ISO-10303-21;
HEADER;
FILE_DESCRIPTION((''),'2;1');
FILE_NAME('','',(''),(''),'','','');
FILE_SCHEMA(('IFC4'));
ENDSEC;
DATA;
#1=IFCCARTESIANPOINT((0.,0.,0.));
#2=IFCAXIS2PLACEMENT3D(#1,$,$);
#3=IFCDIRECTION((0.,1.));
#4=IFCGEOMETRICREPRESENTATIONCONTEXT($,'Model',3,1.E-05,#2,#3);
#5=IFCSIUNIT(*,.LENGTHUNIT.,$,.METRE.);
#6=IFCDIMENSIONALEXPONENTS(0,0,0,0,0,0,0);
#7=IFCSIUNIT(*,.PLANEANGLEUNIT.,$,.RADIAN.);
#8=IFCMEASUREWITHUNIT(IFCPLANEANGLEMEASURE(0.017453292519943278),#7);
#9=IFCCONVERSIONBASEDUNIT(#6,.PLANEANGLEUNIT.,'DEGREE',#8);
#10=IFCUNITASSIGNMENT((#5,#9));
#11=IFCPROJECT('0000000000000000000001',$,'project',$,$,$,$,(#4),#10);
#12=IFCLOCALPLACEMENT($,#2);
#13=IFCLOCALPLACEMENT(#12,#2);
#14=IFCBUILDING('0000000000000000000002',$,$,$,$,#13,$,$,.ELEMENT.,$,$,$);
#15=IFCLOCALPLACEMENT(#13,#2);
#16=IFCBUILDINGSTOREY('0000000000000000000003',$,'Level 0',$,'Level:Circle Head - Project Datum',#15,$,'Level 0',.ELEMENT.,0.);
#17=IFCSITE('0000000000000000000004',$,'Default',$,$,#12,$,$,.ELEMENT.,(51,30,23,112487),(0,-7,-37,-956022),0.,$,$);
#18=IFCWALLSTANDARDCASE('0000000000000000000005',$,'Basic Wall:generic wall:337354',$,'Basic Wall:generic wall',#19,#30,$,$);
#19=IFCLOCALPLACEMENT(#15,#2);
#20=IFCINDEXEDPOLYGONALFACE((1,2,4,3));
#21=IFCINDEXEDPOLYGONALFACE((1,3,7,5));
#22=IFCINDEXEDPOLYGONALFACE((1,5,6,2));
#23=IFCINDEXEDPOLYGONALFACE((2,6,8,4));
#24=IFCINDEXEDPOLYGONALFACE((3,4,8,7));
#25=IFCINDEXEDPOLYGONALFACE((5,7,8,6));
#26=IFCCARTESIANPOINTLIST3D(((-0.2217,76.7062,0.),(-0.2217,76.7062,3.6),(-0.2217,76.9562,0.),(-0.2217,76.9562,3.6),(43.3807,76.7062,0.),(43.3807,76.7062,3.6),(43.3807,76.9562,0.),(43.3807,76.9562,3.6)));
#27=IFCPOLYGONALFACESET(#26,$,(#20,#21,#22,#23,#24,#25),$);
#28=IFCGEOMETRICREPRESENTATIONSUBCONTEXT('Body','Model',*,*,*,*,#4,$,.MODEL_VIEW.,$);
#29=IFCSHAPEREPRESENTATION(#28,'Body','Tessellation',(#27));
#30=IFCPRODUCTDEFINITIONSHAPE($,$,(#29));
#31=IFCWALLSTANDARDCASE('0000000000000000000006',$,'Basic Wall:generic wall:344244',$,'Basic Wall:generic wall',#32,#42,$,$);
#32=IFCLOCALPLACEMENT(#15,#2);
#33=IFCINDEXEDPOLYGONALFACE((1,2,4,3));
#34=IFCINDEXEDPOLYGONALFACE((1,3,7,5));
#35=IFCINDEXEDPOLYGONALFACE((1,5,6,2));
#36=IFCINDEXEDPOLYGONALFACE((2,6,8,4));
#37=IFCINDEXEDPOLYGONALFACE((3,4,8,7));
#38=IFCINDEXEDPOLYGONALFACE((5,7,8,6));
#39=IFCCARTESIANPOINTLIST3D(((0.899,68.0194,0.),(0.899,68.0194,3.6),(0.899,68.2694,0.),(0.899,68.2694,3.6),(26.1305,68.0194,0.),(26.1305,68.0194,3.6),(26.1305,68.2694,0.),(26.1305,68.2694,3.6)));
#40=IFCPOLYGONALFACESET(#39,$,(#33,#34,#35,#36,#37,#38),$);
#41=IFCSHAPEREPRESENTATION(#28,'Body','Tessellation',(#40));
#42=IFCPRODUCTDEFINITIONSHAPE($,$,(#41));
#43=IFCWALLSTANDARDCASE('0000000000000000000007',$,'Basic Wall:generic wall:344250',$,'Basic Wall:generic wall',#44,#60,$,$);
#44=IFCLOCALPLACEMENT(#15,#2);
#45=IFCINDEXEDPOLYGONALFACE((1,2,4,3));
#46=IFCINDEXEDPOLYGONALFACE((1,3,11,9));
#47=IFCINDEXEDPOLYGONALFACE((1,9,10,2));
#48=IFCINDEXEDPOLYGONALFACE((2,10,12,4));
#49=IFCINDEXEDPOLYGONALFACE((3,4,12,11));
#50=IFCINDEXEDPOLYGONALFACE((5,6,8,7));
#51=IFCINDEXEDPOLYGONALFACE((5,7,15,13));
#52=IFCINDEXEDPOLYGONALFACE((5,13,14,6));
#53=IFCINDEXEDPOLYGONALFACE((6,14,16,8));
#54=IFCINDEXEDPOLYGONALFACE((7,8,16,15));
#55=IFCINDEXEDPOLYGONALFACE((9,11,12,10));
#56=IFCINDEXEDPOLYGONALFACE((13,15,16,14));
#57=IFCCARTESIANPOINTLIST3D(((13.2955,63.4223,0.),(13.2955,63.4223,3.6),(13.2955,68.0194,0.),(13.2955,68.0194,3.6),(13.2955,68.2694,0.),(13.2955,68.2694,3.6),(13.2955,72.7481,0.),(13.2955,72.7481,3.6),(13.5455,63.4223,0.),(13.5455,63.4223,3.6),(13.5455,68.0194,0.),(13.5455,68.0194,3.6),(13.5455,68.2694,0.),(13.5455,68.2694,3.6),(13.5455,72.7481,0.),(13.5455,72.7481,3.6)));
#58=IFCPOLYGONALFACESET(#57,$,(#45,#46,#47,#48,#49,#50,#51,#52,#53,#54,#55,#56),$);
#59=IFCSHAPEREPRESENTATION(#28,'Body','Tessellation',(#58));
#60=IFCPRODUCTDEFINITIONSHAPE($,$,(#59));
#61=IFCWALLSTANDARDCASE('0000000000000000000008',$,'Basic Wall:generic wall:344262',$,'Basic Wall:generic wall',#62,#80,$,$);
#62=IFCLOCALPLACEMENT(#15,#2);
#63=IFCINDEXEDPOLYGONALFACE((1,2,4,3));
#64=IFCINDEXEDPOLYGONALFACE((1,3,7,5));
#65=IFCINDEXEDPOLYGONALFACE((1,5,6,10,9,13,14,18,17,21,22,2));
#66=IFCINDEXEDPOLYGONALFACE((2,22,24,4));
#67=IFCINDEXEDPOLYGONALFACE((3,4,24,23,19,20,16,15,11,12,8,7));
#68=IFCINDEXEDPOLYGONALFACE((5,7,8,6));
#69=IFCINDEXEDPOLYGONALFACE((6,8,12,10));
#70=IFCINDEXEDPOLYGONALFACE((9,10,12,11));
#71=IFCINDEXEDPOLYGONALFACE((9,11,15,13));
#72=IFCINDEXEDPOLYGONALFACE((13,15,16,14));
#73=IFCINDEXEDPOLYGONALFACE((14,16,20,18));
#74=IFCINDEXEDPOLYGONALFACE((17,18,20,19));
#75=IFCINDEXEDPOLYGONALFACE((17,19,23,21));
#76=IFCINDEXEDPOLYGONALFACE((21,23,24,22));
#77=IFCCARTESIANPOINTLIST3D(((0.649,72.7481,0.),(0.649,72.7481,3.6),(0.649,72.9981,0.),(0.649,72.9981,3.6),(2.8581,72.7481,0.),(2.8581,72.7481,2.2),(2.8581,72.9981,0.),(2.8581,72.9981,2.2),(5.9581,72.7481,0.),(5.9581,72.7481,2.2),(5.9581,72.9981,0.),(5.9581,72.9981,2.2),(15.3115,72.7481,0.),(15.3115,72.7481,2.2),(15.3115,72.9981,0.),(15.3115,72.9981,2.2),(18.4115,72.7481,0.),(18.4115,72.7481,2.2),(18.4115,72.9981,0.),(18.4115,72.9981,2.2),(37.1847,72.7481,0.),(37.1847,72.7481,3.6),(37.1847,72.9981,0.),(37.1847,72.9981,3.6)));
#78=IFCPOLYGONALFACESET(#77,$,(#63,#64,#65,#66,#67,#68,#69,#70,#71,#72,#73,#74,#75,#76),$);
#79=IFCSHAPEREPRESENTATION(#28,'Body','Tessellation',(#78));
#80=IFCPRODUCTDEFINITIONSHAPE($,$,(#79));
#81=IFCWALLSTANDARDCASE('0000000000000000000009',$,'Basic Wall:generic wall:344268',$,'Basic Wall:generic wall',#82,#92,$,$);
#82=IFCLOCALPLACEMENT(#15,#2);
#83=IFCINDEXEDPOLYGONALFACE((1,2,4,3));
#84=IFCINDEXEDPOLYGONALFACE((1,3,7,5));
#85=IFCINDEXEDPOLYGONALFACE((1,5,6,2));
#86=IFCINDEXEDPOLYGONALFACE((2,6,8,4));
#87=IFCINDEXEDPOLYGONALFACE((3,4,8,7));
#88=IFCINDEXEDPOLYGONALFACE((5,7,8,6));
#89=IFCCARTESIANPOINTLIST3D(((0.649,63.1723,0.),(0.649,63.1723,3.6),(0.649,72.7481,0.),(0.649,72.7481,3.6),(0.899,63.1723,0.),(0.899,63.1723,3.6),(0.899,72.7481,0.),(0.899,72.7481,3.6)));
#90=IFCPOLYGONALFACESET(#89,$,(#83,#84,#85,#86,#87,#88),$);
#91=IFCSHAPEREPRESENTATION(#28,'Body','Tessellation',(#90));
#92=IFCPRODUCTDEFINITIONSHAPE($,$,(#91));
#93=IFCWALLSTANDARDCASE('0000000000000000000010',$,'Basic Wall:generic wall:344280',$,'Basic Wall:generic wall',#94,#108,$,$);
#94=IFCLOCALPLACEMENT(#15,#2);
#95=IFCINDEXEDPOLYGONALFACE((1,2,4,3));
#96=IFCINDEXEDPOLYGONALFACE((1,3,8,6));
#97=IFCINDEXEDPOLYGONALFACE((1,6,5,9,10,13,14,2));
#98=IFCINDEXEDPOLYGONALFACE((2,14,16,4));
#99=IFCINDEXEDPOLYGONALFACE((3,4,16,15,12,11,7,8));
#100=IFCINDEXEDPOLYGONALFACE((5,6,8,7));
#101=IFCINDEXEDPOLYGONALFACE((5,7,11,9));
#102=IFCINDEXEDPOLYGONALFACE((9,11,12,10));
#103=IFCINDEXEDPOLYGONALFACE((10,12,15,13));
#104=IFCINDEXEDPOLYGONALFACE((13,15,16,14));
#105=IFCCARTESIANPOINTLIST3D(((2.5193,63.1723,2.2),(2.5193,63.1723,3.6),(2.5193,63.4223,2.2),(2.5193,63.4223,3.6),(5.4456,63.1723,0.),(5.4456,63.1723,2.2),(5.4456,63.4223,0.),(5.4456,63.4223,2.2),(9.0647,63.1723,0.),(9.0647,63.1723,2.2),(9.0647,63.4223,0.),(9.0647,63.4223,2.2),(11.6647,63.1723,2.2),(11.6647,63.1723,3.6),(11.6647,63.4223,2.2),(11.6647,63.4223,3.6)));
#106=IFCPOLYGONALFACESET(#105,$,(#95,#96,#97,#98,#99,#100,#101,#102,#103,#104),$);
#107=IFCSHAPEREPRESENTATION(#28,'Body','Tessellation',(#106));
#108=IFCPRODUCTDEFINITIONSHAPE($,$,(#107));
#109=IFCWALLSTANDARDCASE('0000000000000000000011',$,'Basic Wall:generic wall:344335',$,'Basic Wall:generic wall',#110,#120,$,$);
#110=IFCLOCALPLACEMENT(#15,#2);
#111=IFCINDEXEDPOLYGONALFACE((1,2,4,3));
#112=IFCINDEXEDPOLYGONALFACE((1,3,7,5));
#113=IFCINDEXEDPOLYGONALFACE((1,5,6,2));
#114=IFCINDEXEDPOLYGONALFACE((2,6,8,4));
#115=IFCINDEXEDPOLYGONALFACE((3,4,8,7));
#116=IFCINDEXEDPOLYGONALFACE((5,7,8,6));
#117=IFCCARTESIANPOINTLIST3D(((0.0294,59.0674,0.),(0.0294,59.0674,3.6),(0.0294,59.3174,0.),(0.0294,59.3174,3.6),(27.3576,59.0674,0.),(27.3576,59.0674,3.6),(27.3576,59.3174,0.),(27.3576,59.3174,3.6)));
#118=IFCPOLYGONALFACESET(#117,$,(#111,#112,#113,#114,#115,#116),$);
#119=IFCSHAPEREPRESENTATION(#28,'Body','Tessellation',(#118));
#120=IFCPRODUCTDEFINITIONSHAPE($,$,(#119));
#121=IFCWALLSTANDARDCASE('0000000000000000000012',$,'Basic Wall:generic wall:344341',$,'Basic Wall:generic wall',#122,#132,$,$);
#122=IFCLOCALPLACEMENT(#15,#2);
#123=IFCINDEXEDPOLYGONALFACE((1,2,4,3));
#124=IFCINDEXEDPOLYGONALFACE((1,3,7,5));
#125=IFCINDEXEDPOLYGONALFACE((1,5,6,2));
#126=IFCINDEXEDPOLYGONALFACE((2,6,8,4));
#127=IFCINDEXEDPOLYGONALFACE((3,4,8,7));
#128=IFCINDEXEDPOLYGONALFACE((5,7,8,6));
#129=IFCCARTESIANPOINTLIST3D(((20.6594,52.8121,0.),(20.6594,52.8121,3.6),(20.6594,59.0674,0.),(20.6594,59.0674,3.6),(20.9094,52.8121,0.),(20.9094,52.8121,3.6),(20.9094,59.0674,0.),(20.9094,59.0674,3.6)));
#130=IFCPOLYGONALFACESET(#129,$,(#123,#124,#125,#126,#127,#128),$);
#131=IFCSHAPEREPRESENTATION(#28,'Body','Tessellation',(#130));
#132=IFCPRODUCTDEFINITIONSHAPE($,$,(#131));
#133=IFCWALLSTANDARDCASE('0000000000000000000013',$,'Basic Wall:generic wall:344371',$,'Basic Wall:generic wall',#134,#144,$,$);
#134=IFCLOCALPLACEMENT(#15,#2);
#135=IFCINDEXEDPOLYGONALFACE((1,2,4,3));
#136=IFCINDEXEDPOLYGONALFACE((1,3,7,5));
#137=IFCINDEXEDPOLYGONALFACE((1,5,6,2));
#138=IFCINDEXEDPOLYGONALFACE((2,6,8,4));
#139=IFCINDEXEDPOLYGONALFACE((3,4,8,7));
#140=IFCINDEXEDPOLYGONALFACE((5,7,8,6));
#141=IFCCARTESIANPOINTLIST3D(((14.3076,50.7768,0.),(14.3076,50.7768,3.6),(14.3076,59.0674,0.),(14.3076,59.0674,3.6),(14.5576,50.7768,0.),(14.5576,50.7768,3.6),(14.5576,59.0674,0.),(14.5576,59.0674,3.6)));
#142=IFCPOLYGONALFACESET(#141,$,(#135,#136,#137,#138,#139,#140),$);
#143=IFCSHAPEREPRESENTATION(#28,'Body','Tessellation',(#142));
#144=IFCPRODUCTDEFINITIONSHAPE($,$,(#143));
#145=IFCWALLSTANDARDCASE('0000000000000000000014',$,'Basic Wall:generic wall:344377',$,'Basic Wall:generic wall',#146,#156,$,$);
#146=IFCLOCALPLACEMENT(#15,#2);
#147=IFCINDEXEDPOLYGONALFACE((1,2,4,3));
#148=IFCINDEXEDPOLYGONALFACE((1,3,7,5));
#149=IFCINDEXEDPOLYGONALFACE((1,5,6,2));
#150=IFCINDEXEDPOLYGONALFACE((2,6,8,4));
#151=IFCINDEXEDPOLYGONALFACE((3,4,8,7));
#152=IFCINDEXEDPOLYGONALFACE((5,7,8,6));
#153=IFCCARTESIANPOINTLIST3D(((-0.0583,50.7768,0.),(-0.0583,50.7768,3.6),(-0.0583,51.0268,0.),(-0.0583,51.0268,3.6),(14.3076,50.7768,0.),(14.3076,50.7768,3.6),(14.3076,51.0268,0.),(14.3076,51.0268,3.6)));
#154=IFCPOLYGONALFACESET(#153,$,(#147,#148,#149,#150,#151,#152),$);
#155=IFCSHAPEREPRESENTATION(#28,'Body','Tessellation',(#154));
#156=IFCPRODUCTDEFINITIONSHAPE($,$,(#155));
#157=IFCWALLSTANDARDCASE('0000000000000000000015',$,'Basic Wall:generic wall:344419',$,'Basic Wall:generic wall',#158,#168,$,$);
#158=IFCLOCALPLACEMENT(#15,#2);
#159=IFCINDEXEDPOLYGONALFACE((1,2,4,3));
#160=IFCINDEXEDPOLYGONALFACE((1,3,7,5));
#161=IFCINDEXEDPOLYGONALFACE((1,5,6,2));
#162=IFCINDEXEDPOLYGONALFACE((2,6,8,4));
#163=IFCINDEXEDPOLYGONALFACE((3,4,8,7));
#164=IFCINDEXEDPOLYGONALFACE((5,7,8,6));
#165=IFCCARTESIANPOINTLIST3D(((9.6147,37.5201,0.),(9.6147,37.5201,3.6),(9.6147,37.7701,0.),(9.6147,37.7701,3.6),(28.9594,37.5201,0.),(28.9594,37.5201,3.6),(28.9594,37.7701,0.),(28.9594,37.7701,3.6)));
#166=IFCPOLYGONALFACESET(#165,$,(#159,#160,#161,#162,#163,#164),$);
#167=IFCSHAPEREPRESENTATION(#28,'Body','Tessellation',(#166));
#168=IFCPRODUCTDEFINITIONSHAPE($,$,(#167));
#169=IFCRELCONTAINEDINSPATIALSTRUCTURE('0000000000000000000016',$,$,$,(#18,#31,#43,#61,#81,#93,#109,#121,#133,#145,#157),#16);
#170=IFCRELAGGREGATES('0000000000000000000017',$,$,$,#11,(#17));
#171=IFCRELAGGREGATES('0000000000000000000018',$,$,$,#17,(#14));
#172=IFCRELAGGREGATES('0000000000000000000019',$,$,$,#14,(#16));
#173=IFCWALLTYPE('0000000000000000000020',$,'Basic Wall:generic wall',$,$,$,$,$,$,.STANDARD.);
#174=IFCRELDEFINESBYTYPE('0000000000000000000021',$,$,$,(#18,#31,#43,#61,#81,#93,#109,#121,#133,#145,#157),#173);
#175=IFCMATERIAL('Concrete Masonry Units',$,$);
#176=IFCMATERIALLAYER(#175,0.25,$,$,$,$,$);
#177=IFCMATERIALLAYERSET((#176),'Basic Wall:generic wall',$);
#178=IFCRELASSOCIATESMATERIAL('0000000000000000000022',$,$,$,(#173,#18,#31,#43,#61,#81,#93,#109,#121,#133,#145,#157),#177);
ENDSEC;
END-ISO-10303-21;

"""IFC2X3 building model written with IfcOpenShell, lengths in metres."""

from ifc_helpers import new_model, entity, si_unit, converted_unit, direction, frame, frame_2d, origin, place, context, subcontext, project, spatial, rectangle, extrude, material, layer, layer_set, layer_usage, type_object, element, save


model = new_model("IFC2X3")

# Units and contexts
model_context = context("Model", 3, precision=1e-05, world=origin(), true_north=direction((0.0, 1.0)))
body_context = subcontext(model_context, "Body", "Model", "MODEL_VIEW")
ifc_project = project(units=[si_unit("LENGTHUNIT", "METRE"), converted_unit("PLANEANGLEUNIT", "DEGREE", entity("IfcPlaneAngleMeasure", 0.017453292519943278), si_unit("PLANEANGLEUNIT", "RADIAN"), dimensions=[0, 0, 0, 0, 0, 0, 0])], contexts=[model_context])

# Site, building, storey
site_placement = place(None, origin())
site = spatial("IfcSite", under=ifc_project, at=site_placement, Name="Default", CompositionType="ELEMENT", RefLatitude=(51, 30, 23, 112487), RefLongitude=(0, -7, -37, -956022), RefElevation=0.0)
building_placement = place(site_placement, origin())
building = spatial("IfcBuilding", under=site, at=building_placement, CompositionType="ELEMENT")
storey_placement = place(building_placement, origin())
storey = spatial("IfcBuildingStorey", under=building, at=storey_placement, Name="Level 0", ObjectType="Level:Circle Head - Project Datum", LongName="Level 0", CompositionType="ELEMENT", Elevation=0.0)

# Walls
ifc_material_1 = material(Name="Concrete Masonry Units")
ifc_layer_1 = layer(ifc_material_1, 0.25)
ifc_layer_set_1 = layer_set([ifc_layer_1], Name="Basic Wall:generic wall")
ifc_layer_usage_1 = layer_usage(ifc_layer_set_1, "AXIS2", "POSITIVE", -0.125)
wall_type_1 = type_object("IfcWallType", Name="Basic Wall:generic wall", PredefinedType="STANDARD", material=ifc_layer_set_1)
wall_1_placement = place(storey_placement, frame((-0.2217, 76.8312, 0.0)))
element("IfcWallStandardCase", 1, at=wall_1_placement, inside=storey, type_object=wall_type_1, material=ifc_layer_usage_1, Name="Basic Wall:generic wall:337354", ObjectType="Basic Wall:generic wall", context=body_context, shape_type="SweptSolid", body=[
    extrude(rectangle(XDim=43.6023, YDim=0.25, at=frame_2d((21.8012, 0.0), x_axis=(-1.0, 0.0))), origin(), (0.0, 0.0, 1.0), 3.6),
])
ifc_layer_usage_2 = layer_usage(ifc_layer_set_1, "AXIS2", "NEGATIVE", 0.125)
wall_2_placement = place(storey_placement, frame((0.899, 68.1444, 0.0)))
element("IfcWallStandardCase", 2, at=wall_2_placement, inside=storey, type_object=wall_type_1, material=ifc_layer_usage_2, Name="Basic Wall:generic wall:344244", ObjectType="Basic Wall:generic wall", context=body_context, shape_type="SweptSolid", body=[
    extrude(rectangle(XDim=25.2315, YDim=0.25, at=frame_2d((12.6158, 0.0), x_axis=(-1.0, 0.0))), origin(), (0.0, 0.0, 1.0), 3.6),
])

# Wall, opening
ifc_layer_usage_3 = layer_usage(ifc_layer_set_1, "AXIS2", "NEGATIVE", 0.125)
wall_3_placement = place(storey_placement, frame((13.4205, 72.7481, 0.0), z_axis=(0.0, 0.0, 1.0), x_axis=(0.0, -1.0, 0.0)))
wall_3 = element("IfcWallStandardCase", 3, at=wall_3_placement, inside=storey, type_object=wall_type_1, material=ifc_layer_usage_3, Name="Basic Wall:generic wall:344250", ObjectType="Basic Wall:generic wall", context=body_context, shape_type="SweptSolid", body=[
    extrude(rectangle(XDim=9.3259, YDim=0.25, at=frame_2d((4.6629, 0.0), x_axis=(-1.0, 0.0))), origin(), (0.0, 0.0, 1.0), 3.6),
])
opening_1_placement = place(storey_placement, frame((13.4205, 72.7481, 0.0), z_axis=(0.0, 0.0, 1.0), x_axis=(0.0, -1.0, 0.0)))
element("IfcOpeningElement", 4, at=opening_1_placement, cuts=wall_3, ObjectType="Opening", context=body_context, shape_type="SweptSolid", body=[
    extrude(rectangle(XDim=3.6, YDim=0.25, at=frame_2d((0.0, 0.0), x_axis=(1.0, 0.0))), frame((4.7287, 0.0, 1.8), z_axis=(-1.0, 0.0, 0.0), x_axis=(0.0, 0.0, 1.0)), (0.0, 0.0, 1.0), 0.25),
])

# Wall, openings
ifc_layer_usage_4 = layer_usage(ifc_layer_set_1, "AXIS2", "NEGATIVE", 0.125)
wall_4_placement = place(storey_placement, frame((0.649, 72.8731, 0.0)))
wall_4 = element("IfcWallStandardCase", 5, at=wall_4_placement, inside=storey, type_object=wall_type_1, material=ifc_layer_usage_4, Name="Basic Wall:generic wall:344262", ObjectType="Basic Wall:generic wall", context=body_context, shape_type="SweptSolid", body=[
    extrude(rectangle(XDim=36.5356, YDim=0.25, at=frame_2d((18.2678, 0.0), x_axis=(1.0, 0.0))), origin(), (0.0, 0.0, 1.0), 3.6),
])
opening_2_placement = place(wall_4_placement, frame((5.3091, 0.125, 0.0)))
element("IfcOpeningElement", 6, at=opening_2_placement, cuts=wall_4, ObjectType="Opening", context=body_context, shape_type="SweptSolid", body=[
    extrude(rectangle(XDim=2.2, YDim=3.1, at=frame_2d((1.1, 1.55), x_axis=(1.0, 0.0))), frame((0.0, 0.0, 0.0), z_axis=(0.0, -1.0, 0.0), x_axis=(0.0, 0.0, 1.0)), (0.0, 0.0, 1.0), 0.25),
])
opening_3_placement = place(wall_4_placement, frame((17.7625, 0.125, 0.0)))
element("IfcOpeningElement", 7, at=opening_3_placement, cuts=wall_4, ObjectType="Opening", context=body_context, shape_type="SweptSolid", body=[
    extrude(rectangle(XDim=2.2, YDim=3.1, at=frame_2d((1.1, 1.55), x_axis=(1.0, 0.0))), frame((0.0, 0.0, 0.0), z_axis=(0.0, -1.0, 0.0), x_axis=(0.0, 0.0, 1.0)), (0.0, 0.0, 1.0), 0.25),
])

# Wall
ifc_layer_usage_5 = layer_usage(ifc_layer_set_1, "AXIS2", "NEGATIVE", 0.125)
wall_5_placement = place(storey_placement, frame((0.774, 63.1723, 0.0), z_axis=(0.0, 0.0, 1.0), x_axis=(0.0, 1.0, 0.0)))
element("IfcWallStandardCase", 8, at=wall_5_placement, inside=storey, type_object=wall_type_1, material=ifc_layer_usage_5, Name="Basic Wall:generic wall:344268", ObjectType="Basic Wall:generic wall", context=body_context, shape_type="SweptSolid", body=[
    extrude(rectangle(XDim=9.5759, YDim=0.25, at=frame_2d((4.7879, 0.0), x_axis=(-1.0, 0.0))), origin(), (0.0, 0.0, 1.0), 3.6),
])

# Wall, openings
ifc_layer_usage_6 = layer_usage(ifc_layer_set_1, "AXIS2", "NEGATIVE", 0.125)
wall_6_placement = place(storey_placement, frame((11.6647, 63.2973, 0.0), z_axis=(0.0, 0.0, 1.0), x_axis=(-1.0, 0.0, 0.0)))
wall_6 = element("IfcWallStandardCase", 9, at=wall_6_placement, inside=storey, type_object=wall_type_1, material=ifc_layer_usage_6, Name="Basic Wall:generic wall:344280", ObjectType="Basic Wall:generic wall", context=body_context, shape_type="SweptSolid", body=[
    extrude(rectangle(XDim=9.1454, YDim=0.25, at=frame_2d((4.5727, 0.0), x_axis=(-1.0, 0.0))), origin(), (0.0, 0.0, 1.0), 3.6),
])
opening_4_placement = place(wall_6_placement, frame((9.319, 0.125, 0.0)))
element("IfcOpeningElement", 10, at=opening_4_placement, cuts=wall_6, ObjectType="Opening", context=body_context, shape_type="SweptSolid", body=[
    extrude(rectangle(XDim=2.2, YDim=3.1, at=frame_2d((1.1, 1.55), x_axis=(1.0, 0.0))), frame((0.0, 0.0, 0.0), z_axis=(0.0, -1.0, 0.0), x_axis=(0.0, 0.0, 1.0)), (0.0, 0.0, 1.0), 0.25),
])
opening_5_placement = place(wall_6_placement, frame((2.6, 0.125, 0.0)))
element("IfcOpeningElement", 11, at=opening_5_placement, cuts=wall_6, ObjectType="Opening", context=body_context, shape_type="SweptSolid", body=[
    extrude(rectangle(XDim=2.2, YDim=3.1, at=frame_2d((1.1, 1.55), x_axis=(1.0, 0.0))), frame((0.0, 0.0, 0.0), z_axis=(0.0, -1.0, 0.0), x_axis=(0.0, 0.0, 1.0)), (0.0, 0.0, 1.0), 0.25),
])

# Walls
ifc_layer_usage_7 = layer_usage(ifc_layer_set_1, "AXIS2", "NEGATIVE", 0.125)
wall_7_placement = place(storey_placement, frame((0.0294, 59.1924, 0.0)))
element("IfcWallStandardCase", 12, at=wall_7_placement, inside=storey, type_object=wall_type_1, material=ifc_layer_usage_7, Name="Basic Wall:generic wall:344335", ObjectType="Basic Wall:generic wall", context=body_context, shape_type="SweptSolid", body=[
    extrude(rectangle(XDim=27.3282, YDim=0.25, at=frame_2d((13.6641, 0.0), x_axis=(-1.0, 0.0))), origin(), (0.0, 0.0, 1.0), 3.6),
])
ifc_layer_usage_8 = layer_usage(ifc_layer_set_1, "AXIS2", "NEGATIVE", 0.125)
wall_8_placement = place(storey_placement, frame((20.7844, 59.0674, 0.0), z_axis=(0.0, 0.0, 1.0), x_axis=(0.0, -1.0, 0.0)))
element("IfcWallStandardCase", 13, at=wall_8_placement, inside=storey, type_object=wall_type_1, material=ifc_layer_usage_8, Name="Basic Wall:generic wall:344341", ObjectType="Basic Wall:generic wall", context=body_context, shape_type="SweptSolid", body=[
    extrude(rectangle(XDim=6.2553, YDim=0.25, at=frame_2d((3.1276, 0.0), x_axis=(-1.0, 0.0))), origin(), (0.0, 0.0, 1.0), 3.6),
])
ifc_layer_usage_9 = layer_usage(ifc_layer_set_1, "AXIS2", "NEGATIVE", 0.125)
wall_9_placement = place(storey_placement, frame((14.4326, 50.7768, 0.0), z_axis=(0.0, 0.0, 1.0), x_axis=(0.0, 1.0, 0.0)))
element("IfcWallStandardCase", 14, at=wall_9_placement, inside=storey, type_object=wall_type_1, material=ifc_layer_usage_9, Name="Basic Wall:generic wall:344371", ObjectType="Basic Wall:generic wall", context=body_context, shape_type="SweptSolid", body=[
    extrude(rectangle(XDim=8.2906, YDim=0.25, at=frame_2d((4.1453, 0.0), x_axis=(-1.0, 0.0))), origin(), (0.0, 0.0, 1.0), 3.6),
])
ifc_layer_usage_10 = layer_usage(ifc_layer_set_1, "AXIS2", "NEGATIVE", 0.125)
wall_10_placement = place(storey_placement, frame((-0.0583, 50.9018, 0.0)))
element("IfcWallStandardCase", 15, at=wall_10_placement, inside=storey, type_object=wall_type_1, material=ifc_layer_usage_10, Name="Basic Wall:generic wall:344377", ObjectType="Basic Wall:generic wall", context=body_context, shape_type="SweptSolid", body=[
    extrude(rectangle(XDim=14.3659, YDim=0.25, at=frame_2d((7.1829, 0.0), x_axis=(-1.0, 0.0))), origin(), (0.0, 0.0, 1.0), 3.6),
])
ifc_layer_usage_11 = layer_usage(ifc_layer_set_1, "AXIS2", "NEGATIVE", 0.125)
wall_11_placement = place(storey_placement, frame((9.6147, 37.6451, 0.0)))
element("IfcWallStandardCase", 16, at=wall_11_placement, inside=storey, type_object=wall_type_1, material=ifc_layer_usage_11, Name="Basic Wall:generic wall:344419", ObjectType="Basic Wall:generic wall", context=body_context, shape_type="SweptSolid", body=[
    extrude(rectangle(XDim=19.3447, YDim=0.25, at=frame_2d((9.6723, 0.0), x_axis=(-1.0, 0.0))), origin(), (0.0, 0.0, 1.0), 3.6),
])

save(model, "model.ifc")
